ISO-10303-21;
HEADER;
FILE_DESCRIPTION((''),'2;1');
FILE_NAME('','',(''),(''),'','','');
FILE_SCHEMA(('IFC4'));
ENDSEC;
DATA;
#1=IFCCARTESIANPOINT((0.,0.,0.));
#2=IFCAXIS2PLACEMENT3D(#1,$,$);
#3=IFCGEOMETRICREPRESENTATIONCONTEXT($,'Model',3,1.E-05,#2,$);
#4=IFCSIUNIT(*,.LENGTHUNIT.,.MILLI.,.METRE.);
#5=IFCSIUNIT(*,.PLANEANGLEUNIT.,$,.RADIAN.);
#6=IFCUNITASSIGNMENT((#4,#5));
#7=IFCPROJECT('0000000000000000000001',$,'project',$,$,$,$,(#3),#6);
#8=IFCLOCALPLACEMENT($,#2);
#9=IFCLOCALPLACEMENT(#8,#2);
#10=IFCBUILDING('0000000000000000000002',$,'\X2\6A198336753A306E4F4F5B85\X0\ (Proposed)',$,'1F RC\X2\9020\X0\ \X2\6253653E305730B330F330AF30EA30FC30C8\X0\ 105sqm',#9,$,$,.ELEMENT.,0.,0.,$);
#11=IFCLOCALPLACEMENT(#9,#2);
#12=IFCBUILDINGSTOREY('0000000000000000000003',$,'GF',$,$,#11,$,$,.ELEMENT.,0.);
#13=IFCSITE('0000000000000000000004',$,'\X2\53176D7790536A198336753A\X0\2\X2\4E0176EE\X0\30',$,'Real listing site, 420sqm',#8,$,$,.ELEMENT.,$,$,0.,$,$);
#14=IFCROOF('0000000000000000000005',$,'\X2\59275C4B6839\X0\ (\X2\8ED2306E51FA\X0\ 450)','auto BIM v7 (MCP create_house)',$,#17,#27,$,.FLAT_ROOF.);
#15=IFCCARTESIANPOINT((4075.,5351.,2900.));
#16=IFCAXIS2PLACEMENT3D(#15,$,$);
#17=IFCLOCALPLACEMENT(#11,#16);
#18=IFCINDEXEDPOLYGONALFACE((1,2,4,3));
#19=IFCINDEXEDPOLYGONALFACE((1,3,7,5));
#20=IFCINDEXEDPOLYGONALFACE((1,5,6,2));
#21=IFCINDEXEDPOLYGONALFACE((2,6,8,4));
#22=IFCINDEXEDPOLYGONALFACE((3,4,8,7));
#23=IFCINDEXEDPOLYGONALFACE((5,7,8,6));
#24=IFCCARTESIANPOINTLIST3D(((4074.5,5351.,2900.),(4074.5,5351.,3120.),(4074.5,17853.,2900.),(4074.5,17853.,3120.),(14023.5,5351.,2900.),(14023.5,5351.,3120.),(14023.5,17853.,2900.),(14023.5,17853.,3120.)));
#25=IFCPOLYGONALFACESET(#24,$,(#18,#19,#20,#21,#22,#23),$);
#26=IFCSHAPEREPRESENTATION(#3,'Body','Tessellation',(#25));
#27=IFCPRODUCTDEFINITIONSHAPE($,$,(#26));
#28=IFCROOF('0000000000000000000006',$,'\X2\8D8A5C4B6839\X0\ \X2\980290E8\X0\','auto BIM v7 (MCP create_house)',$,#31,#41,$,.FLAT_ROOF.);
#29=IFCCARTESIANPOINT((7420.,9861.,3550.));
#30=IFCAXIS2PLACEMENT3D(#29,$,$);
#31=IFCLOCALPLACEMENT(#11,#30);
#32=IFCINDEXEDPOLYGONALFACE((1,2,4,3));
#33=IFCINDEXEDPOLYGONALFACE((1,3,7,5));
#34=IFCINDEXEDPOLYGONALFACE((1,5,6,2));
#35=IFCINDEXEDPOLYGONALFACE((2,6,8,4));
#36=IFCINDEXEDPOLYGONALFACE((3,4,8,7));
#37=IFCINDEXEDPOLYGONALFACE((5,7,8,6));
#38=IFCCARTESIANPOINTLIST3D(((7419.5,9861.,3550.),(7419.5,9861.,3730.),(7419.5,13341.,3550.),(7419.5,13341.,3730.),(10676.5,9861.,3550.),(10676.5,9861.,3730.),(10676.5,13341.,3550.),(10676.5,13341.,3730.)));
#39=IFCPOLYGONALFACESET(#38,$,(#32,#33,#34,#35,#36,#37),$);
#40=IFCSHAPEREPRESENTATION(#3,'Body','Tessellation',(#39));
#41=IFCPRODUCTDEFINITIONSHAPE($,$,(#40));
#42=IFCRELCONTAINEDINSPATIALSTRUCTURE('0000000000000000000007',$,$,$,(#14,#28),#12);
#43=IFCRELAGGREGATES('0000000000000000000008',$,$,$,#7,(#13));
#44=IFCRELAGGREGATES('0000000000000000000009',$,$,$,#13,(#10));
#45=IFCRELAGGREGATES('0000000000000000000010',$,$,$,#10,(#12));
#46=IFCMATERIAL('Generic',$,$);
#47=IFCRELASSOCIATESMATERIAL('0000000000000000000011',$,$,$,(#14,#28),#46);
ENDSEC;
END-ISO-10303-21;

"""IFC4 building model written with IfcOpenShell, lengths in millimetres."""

from ifc_helpers import new_model, si_unit, frame, frame_2d, origin, place, context, project, spatial, rectangle, extrude, material, element, save


model = new_model("IFC4")

# Units and contexts
model_context = context("Model", 3, precision=1e-05, world=origin())
ifc_project = project(units=[si_unit("LENGTHUNIT", "METRE", prefix="MILLI"), si_unit("PLANEANGLEUNIT", "RADIAN")], contexts=[model_context])

# Site, building, storey
site_placement = place(None, origin())
site = spatial("IfcSite", under=ifc_project, at=site_placement, Name="北海道標茶町2丁目30", ObjectType="Real listing site, 420sqm", CompositionType="ELEMENT", RefElevation=0.0)
building_placement = place(site_placement, origin())
building = spatial("IfcBuilding", under=site, at=building_placement, Name="標茶町の住宅 (Proposed)", ObjectType="1F RC造 打放しコンクリート 105sqm", CompositionType="ELEMENT", ElevationOfRefHeight=0.0, ElevationOfTerrain=0.0)
storey_placement = place(building_placement, origin())
storey = spatial("IfcBuildingStorey", under=building, at=storey_placement, Name="GF", CompositionType="ELEMENT", Elevation=0.0)

# Shared definitions
ifc_material = material(Name="Generic")

# Roofs
roof_1_placement = place(storey_placement, frame((4075.0, 5351.0, 2900.0)))
element("IfcRoof", 1, at=roof_1_placement, inside=storey, material=ifc_material, Name="大屋根 (軒の出 450)", Description="auto BIM v7 (MCP create_house)", PredefinedType="FLAT_ROOF", context=model_context, shape_type="SweptSolid", body=[
    extrude(rectangle(XDim=9949.0, YDim=12502.0, at=frame_2d((4974.0, 6251.0))), frame((4075.0, 5351.0, 2900.0)), (0.0, 0.0, 1.0), 220.0),
])
roof_2_placement = place(storey_placement, frame((7420.0, 9861.0, 3550.0)))
element("IfcRoof", 2, at=roof_2_placement, inside=storey, material=ifc_material, Name="越屋根 頂部", Description="auto BIM v7 (MCP create_house)", PredefinedType="FLAT_ROOF", context=model_context, shape_type="SweptSolid", body=[
    extrude(rectangle(XDim=3257.0, YDim=3480.0, at=frame_2d((1628.0, 1740.0))), frame((7420.0, 9861.0, 3550.0)), (0.0, 0.0, 1.0), 180.0),
])

save(model, "model.ifc")
